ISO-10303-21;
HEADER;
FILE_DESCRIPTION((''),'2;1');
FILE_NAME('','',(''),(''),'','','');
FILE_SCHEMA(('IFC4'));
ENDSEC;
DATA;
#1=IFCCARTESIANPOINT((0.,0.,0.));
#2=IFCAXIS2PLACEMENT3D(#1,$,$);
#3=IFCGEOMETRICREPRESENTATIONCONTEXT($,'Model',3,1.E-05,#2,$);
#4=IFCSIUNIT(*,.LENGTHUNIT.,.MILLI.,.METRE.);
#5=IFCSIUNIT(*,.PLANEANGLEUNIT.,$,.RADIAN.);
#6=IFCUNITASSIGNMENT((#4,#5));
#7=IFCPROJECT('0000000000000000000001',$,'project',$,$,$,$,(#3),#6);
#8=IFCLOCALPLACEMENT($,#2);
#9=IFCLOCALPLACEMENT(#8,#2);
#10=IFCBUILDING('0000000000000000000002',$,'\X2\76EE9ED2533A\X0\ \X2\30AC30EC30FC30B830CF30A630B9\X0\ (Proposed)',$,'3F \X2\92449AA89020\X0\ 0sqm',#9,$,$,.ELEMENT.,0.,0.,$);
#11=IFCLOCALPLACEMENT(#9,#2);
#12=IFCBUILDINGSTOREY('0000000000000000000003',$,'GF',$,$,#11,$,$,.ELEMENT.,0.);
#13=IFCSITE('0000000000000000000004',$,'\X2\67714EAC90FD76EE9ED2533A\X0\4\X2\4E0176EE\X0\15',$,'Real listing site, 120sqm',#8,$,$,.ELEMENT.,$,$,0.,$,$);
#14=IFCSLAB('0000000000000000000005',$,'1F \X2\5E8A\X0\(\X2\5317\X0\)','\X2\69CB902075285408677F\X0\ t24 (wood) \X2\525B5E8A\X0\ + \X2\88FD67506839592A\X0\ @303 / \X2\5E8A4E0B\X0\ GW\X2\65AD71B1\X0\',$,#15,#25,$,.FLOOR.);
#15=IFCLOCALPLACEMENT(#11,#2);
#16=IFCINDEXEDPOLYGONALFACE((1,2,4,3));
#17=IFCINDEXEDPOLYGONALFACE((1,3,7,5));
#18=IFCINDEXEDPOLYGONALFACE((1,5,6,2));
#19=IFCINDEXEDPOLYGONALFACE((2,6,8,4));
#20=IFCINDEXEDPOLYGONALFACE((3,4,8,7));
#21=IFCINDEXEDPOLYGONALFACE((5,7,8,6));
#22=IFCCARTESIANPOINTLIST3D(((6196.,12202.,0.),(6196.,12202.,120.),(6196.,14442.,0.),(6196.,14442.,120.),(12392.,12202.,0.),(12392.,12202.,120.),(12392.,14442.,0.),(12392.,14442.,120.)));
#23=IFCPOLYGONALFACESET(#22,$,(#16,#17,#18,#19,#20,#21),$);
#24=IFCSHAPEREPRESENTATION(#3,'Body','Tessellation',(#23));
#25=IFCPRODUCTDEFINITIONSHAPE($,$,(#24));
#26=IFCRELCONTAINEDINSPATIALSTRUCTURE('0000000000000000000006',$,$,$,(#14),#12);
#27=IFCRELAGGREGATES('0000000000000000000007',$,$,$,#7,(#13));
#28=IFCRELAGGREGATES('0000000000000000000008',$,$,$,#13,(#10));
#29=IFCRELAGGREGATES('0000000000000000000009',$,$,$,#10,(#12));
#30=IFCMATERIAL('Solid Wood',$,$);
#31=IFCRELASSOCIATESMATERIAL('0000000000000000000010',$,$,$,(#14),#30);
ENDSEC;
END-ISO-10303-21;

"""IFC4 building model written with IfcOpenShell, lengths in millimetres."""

from ifc_helpers import new_model, si_unit, frame, frame_2d, origin, place, context, project, spatial, rectangle, extrude, material, element, save


model = new_model("IFC4")

# Units and contexts
model_context = context("Model", 3, precision=1e-05, world=origin())
ifc_project = project(units=[si_unit("LENGTHUNIT", "METRE", prefix="MILLI"), si_unit("PLANEANGLEUNIT", "RADIAN")], contexts=[model_context])

# Site, building, storey
site_placement = place(None, origin())
site = spatial("IfcSite", under=ifc_project, at=site_placement, Name="東京都目黒区4丁目15", ObjectType="Real listing site, 120sqm", CompositionType="ELEMENT", RefElevation=0.0)
building_placement = place(site_placement, origin())
building = spatial("IfcBuilding", under=site, at=building_placement, Name="目黒区 ガレージハウス (Proposed)", ObjectType="3F 鉄骨造 0sqm", CompositionType="ELEMENT", ElevationOfRefHeight=0.0, ElevationOfTerrain=0.0)
storey_placement = place(building_placement, origin())
storey = spatial("IfcBuildingStorey", under=building, at=storey_placement, Name="GF", CompositionType="ELEMENT", Elevation=0.0)

# Slab
ifc_material_1 = material(Name="Solid Wood")
slab_1_placement = place(storey_placement, frame((3098.0, 6101.0, 0.0)))
element("IfcSlab", 1, at=slab_1_placement, inside=storey, material=ifc_material_1, Name="1F 床(北)", Description="構造用合板 t24 (wood) 剛床 + 製材根太 @303 / 床下 GW断熱", PredefinedType="FLOOR", context=model_context, shape_type="SweptSolid", body=[
    extrude(rectangle(XDim=6196.0, YDim=2240.0, at=frame_2d((3098.0, 1120.0))), frame((3098.0, 6101.0, 0.0)), (0.0, 0.0, 1.0), 120.0),
])

save(model, "model.ifc")
